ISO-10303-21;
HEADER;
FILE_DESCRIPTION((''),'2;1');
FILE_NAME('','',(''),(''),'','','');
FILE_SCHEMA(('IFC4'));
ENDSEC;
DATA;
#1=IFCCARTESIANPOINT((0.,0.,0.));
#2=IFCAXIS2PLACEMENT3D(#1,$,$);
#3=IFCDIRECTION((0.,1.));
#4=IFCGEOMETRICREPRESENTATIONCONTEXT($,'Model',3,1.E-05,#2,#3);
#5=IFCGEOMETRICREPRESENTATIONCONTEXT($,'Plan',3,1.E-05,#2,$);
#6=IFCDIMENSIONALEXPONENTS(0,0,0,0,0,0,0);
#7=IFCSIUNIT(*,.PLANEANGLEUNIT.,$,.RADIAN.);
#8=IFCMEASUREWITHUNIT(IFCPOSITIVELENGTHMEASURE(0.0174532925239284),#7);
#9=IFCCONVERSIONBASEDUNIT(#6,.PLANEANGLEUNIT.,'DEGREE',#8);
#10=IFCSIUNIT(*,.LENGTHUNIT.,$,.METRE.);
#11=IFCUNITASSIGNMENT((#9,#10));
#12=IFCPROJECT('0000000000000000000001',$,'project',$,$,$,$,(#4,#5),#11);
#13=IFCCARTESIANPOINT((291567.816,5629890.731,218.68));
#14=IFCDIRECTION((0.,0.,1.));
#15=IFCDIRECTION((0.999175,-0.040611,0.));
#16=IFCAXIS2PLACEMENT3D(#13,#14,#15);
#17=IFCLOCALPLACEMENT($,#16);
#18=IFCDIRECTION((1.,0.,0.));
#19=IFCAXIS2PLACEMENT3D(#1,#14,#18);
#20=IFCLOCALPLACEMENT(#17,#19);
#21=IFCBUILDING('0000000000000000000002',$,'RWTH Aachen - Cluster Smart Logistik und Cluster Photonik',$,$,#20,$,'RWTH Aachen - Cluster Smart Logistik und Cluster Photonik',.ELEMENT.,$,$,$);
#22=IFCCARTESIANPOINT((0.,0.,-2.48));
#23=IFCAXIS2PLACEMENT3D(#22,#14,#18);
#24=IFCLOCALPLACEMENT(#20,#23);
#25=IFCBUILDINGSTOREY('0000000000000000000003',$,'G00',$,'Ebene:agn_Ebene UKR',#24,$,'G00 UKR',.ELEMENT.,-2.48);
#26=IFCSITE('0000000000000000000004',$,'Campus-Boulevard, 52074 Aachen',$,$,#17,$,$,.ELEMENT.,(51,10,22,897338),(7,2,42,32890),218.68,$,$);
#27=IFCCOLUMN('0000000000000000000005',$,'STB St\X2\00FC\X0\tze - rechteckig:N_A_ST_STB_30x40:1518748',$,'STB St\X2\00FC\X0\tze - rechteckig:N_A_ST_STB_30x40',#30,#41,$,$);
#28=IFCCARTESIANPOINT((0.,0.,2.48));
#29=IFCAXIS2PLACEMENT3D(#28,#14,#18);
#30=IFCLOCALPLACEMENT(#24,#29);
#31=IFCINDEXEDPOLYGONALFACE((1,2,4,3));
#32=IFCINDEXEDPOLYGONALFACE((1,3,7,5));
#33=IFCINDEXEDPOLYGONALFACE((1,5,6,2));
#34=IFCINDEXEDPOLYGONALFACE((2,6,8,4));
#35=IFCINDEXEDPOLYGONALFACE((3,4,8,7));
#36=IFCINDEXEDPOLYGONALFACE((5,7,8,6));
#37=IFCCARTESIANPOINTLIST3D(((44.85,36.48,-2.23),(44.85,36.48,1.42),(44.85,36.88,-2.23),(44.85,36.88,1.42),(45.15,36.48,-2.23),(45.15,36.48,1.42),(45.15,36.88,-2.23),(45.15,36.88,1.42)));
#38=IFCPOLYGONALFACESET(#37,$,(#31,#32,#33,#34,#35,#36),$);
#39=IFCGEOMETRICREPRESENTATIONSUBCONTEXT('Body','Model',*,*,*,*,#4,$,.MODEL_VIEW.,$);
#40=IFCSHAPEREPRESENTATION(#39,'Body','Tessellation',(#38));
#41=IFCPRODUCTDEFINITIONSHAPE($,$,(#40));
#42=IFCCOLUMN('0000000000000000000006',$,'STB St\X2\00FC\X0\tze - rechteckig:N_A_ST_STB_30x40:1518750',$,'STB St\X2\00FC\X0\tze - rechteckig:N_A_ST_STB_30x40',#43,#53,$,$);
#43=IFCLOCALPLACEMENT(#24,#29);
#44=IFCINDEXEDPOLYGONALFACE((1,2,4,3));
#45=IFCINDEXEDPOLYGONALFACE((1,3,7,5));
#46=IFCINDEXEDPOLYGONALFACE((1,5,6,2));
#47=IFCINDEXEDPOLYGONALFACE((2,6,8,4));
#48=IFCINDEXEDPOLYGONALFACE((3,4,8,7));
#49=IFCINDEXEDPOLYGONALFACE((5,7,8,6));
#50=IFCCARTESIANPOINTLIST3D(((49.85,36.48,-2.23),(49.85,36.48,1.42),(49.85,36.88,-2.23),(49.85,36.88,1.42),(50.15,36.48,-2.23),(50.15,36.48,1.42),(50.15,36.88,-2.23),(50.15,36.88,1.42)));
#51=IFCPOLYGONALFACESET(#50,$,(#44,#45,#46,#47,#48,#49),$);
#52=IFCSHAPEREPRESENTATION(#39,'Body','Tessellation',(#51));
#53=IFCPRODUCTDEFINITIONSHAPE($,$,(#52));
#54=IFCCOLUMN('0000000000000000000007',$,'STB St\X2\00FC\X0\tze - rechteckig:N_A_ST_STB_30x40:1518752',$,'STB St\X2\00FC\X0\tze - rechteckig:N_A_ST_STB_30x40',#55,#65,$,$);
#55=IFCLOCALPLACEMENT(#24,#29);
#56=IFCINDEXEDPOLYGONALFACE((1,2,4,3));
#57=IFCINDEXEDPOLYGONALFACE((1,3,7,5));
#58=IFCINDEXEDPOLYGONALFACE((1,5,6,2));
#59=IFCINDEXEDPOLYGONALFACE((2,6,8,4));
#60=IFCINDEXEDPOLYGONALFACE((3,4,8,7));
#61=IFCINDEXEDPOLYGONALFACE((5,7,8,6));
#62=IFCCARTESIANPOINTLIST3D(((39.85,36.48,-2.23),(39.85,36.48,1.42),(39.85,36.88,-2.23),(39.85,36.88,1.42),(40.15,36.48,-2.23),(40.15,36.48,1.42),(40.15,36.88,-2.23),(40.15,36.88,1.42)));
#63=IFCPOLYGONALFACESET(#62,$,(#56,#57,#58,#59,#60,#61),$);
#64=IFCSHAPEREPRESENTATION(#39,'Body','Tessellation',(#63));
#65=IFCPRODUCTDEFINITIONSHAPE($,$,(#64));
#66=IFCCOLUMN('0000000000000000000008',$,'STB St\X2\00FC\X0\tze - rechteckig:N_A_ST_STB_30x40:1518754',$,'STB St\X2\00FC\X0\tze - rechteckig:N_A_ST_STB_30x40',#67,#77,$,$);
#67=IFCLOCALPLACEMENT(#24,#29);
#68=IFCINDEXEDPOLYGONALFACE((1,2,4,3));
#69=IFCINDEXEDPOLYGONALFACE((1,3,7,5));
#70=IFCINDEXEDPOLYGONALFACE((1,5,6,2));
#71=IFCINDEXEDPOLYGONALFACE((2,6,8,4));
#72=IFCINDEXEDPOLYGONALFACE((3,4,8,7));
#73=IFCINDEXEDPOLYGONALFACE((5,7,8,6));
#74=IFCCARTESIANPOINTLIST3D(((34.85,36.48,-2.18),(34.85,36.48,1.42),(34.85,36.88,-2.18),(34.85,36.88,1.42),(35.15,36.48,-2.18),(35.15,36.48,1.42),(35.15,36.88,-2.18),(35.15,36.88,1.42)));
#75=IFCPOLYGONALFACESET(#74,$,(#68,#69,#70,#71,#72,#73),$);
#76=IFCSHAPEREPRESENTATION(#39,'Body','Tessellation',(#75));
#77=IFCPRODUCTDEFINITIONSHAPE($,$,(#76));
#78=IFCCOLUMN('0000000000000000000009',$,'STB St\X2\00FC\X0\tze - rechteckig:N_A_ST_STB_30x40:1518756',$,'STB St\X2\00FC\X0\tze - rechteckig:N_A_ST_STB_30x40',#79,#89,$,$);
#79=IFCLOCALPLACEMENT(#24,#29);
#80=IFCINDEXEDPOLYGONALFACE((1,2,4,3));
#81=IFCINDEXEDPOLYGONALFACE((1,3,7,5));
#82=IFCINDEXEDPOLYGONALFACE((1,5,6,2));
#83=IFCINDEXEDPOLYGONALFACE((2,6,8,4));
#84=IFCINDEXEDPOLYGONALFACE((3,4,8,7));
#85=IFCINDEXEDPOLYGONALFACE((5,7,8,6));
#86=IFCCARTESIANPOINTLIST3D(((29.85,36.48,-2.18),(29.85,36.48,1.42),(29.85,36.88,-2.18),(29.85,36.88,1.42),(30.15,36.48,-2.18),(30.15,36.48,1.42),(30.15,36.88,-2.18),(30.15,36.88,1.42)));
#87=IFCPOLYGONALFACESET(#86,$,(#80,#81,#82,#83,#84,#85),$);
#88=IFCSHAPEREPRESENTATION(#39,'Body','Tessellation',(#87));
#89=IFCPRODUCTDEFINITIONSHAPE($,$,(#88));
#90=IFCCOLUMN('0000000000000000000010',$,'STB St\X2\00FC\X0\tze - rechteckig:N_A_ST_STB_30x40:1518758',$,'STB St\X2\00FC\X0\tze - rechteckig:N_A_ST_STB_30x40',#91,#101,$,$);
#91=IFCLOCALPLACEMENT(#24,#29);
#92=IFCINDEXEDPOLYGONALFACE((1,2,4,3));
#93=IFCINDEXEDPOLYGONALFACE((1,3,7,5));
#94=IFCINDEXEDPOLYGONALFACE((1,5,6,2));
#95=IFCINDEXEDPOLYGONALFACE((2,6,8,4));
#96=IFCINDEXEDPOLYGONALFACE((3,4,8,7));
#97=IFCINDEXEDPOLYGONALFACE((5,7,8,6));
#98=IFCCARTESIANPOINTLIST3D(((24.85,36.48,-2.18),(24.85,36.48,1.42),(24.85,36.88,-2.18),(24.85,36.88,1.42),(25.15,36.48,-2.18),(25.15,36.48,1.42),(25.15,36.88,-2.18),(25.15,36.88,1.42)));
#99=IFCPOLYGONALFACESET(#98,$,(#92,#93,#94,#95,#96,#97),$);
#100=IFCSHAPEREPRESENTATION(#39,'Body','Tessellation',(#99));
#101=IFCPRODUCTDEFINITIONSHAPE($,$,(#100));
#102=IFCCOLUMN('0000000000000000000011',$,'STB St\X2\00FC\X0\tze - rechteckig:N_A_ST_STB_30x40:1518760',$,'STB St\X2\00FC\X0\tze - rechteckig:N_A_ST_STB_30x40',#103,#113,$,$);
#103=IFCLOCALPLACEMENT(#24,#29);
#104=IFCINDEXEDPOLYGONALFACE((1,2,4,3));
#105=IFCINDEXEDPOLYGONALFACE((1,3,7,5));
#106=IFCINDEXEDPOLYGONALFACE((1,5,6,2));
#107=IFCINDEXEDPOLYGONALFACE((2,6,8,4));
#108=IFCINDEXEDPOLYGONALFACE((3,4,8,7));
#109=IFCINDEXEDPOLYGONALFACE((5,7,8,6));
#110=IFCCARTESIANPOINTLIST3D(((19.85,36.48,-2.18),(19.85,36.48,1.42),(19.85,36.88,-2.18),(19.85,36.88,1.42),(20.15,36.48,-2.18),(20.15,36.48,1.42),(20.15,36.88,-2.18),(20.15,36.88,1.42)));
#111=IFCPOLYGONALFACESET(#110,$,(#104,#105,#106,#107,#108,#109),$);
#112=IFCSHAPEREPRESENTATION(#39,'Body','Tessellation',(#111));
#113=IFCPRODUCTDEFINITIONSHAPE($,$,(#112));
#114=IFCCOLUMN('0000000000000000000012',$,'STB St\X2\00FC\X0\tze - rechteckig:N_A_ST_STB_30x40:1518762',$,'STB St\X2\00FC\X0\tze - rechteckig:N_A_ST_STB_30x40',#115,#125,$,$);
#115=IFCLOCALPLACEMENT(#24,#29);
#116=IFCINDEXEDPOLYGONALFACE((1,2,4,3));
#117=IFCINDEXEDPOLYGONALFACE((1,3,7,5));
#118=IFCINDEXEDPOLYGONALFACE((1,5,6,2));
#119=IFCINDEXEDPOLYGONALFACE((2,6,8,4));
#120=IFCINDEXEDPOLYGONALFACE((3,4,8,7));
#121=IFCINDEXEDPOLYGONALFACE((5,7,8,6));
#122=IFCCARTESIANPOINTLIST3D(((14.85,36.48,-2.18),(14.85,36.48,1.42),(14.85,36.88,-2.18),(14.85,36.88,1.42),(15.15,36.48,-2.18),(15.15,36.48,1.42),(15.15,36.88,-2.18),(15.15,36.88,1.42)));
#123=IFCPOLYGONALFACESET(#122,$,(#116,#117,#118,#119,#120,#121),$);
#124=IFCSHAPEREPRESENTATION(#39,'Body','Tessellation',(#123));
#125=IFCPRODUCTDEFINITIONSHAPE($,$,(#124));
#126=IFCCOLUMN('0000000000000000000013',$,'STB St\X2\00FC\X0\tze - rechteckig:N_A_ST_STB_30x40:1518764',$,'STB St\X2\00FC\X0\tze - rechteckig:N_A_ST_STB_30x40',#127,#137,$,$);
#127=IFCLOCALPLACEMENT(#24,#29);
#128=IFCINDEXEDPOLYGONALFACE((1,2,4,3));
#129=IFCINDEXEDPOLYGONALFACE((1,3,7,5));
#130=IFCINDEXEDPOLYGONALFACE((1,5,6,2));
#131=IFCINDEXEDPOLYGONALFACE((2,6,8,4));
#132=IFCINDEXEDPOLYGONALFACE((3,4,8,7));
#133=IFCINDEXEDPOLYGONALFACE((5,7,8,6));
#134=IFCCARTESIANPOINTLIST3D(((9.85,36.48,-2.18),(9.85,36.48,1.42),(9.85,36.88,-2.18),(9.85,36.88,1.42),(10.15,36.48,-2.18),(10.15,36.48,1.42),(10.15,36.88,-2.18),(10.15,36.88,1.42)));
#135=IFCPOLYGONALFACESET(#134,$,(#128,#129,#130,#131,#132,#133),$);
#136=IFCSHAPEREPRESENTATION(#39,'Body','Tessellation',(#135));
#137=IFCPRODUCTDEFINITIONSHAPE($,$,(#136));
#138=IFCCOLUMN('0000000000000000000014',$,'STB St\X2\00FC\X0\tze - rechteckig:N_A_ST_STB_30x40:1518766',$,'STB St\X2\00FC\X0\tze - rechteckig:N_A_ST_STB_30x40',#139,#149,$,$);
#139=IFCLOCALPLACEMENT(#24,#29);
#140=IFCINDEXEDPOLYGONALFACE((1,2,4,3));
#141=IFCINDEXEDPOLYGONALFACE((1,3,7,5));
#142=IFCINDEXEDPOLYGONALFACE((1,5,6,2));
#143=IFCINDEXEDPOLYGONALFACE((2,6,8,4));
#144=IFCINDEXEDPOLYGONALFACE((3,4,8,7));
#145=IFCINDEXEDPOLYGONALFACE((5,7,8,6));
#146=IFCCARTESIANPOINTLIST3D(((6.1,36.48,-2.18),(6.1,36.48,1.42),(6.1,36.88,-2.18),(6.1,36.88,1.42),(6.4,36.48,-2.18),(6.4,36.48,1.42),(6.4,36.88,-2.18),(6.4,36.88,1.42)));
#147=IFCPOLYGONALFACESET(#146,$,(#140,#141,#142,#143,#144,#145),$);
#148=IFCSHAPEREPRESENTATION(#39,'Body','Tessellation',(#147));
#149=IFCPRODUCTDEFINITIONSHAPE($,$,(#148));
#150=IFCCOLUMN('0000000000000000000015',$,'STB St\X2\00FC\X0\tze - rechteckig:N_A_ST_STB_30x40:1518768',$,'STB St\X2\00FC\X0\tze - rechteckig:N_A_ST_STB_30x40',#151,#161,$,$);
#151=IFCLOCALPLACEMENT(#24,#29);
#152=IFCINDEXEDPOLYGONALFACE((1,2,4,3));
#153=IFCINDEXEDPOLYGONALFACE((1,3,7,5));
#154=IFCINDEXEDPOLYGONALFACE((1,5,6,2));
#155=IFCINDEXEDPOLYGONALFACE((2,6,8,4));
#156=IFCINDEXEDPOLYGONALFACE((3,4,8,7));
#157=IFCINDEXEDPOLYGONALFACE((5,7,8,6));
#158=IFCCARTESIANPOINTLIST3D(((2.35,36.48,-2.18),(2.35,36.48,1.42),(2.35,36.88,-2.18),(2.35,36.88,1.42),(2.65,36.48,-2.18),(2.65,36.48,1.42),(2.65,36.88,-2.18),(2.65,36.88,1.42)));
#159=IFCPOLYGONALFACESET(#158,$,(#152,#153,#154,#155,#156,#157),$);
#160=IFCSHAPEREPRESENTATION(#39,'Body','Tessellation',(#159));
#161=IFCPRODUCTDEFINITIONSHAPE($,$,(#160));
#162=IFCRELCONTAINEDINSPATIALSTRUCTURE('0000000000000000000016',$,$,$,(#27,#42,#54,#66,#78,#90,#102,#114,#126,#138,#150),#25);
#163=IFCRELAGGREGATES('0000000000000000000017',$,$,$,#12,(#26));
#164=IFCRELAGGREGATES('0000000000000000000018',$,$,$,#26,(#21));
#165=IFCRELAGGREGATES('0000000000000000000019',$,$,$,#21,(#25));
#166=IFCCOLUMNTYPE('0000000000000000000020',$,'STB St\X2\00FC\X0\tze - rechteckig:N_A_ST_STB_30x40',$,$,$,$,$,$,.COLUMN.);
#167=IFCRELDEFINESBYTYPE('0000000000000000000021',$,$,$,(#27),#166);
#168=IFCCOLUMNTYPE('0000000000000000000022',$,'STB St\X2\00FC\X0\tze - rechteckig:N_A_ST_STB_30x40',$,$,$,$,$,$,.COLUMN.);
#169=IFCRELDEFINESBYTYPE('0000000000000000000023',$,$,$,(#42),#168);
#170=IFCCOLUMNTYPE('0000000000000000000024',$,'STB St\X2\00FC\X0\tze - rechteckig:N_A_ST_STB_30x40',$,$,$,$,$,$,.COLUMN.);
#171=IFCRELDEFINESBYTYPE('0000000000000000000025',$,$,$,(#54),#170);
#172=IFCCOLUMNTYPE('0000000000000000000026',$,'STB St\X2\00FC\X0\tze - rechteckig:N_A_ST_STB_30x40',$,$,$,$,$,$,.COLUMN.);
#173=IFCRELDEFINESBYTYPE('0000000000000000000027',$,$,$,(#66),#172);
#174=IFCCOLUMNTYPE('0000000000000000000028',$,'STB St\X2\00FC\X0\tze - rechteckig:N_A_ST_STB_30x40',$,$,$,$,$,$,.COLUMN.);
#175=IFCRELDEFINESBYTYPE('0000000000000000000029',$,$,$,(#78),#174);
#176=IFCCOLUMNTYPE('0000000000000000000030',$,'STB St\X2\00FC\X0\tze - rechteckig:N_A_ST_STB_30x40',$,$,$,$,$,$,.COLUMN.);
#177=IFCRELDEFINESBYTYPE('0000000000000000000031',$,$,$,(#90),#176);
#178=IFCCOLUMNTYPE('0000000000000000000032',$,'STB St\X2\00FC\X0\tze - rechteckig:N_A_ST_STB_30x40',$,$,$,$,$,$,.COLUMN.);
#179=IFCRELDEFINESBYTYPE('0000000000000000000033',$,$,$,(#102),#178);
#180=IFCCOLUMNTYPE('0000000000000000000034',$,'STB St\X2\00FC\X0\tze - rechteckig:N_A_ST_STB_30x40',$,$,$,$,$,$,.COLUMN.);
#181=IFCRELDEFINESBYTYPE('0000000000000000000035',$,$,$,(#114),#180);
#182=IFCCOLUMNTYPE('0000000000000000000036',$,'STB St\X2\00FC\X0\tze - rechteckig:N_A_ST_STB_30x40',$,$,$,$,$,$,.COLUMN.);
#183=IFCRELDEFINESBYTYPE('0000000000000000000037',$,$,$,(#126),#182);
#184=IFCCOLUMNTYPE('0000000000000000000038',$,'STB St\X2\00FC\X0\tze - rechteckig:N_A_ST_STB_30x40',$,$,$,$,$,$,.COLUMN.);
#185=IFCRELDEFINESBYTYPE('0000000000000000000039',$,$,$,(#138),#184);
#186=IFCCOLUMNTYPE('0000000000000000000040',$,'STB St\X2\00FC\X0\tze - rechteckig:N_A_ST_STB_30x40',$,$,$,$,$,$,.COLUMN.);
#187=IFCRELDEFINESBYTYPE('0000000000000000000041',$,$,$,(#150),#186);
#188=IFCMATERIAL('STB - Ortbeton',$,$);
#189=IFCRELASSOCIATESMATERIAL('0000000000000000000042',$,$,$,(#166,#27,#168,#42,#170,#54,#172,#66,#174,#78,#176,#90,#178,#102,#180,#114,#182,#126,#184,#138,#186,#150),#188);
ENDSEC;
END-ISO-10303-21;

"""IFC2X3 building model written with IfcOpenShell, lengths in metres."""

from ifc_helpers import new_model, entity, si_unit, converted_unit, direction, frame, frame_2d, origin, origin_with_axes, origin_2d_with_axis, place, context, subcontext, project, spatial, rectangle, extrude, source, transform, mapped, material, type_object, element, save


model = new_model("IFC2X3")

# Units and contexts
model_context = context("Model", 3, precision=1e-05, world=origin(), true_north=direction((0.0, 1.0)))
plan_context = context("Plan", 3, precision=1e-05, world=origin())
body_context = subcontext(model_context, "Body", "Model", "MODEL_VIEW")
ifc_project = project(units=[converted_unit("PLANEANGLEUNIT", "DEGREE", entity("IfcPositiveLengthMeasure", 0.0174532925239284), si_unit("PLANEANGLEUNIT", "RADIAN"), dimensions=[0, 0, 0, 0, 0, 0, 0]), si_unit("LENGTHUNIT", "METRE")], contexts=[model_context, plan_context])

# Site, building, storey
site_placement = place(None, frame((291567.816, 5629890.731, 218.68), z_axis=(0.0, 0.0, 1.0), x_axis=(0.999175, -0.040611, 0.0)))
site = spatial("IfcSite", under=ifc_project, at=site_placement, Name="Campus-Boulevard, 52074 Aachen", CompositionType="ELEMENT", RefLatitude=(51, 10, 22, 897338), RefLongitude=(7, 2, 42, 32890), RefElevation=218.68)
building_placement = place(site_placement, origin_with_axes())
building = spatial("IfcBuilding", under=site, at=building_placement, Name="RWTH Aachen - Cluster Smart Logistik und Cluster Photonik", LongName="RWTH Aachen - Cluster Smart Logistik und Cluster Photonik", CompositionType="ELEMENT")
storey_placement = place(building_placement, frame((0.0, 0.0, -2.48), z_axis=(0.0, 0.0, 1.0), x_axis=(1.0, 0.0, 0.0)))
storey = spatial("IfcBuildingStorey", under=building, at=storey_placement, Name="G00", ObjectType="Ebene:agn_Ebene UKR", LongName="G00 UKR", CompositionType="ELEMENT", Elevation=-2.48)

# Shared definitions
ifc_material = material(Name="STB - Ortbeton")

# Columns
column_type_1 = type_object("IfcColumnType", Name="STB Stütze - rechteckig:N_A_ST_STB_30x40", PredefinedType="COLUMN", material=ifc_material)
shared_shape_1 = source(origin(), body_context, "Body", "SweptSolid", [
    extrude(rectangle(XDim=0.4, YDim=0.3, at=frame_2d((0.0, 0.0), x_axis=(1.0, 0.0))), frame((45.0, 36.68, -2.23), z_axis=(0.0, 0.0, 1.0), x_axis=(0.0, -1.0, 0.0)), (0.0, 0.0, 1.0), 3.65),
])
column_1_placement = place(storey_placement, frame((0.0, 0.0, 2.48), z_axis=(0.0, 0.0, 1.0), x_axis=(1.0, 0.0, 0.0)))
element("IfcColumn", 1, at=column_1_placement, inside=storey, type_object=column_type_1, material=ifc_material, Name="STB Stütze - rechteckig:N_A_ST_STB_30x40:1518748", ObjectType="STB Stütze - rechteckig:N_A_ST_STB_30x40", context=body_context, shape_type="MappedRepresentation", body=[
    mapped(shared_shape_1, transform((0.0, 0.0, 0.0), scale=1.0)),
])
column_type_2 = type_object("IfcColumnType", Name="STB Stütze - rechteckig:N_A_ST_STB_30x40", PredefinedType="COLUMN", material=ifc_material)
shared_shape_2 = source(origin(), body_context, "Body", "SweptSolid", [
    extrude(rectangle(XDim=0.4, YDim=0.3, at=frame_2d((0.0, 0.0), x_axis=(1.0, 0.0))), frame((50.0, 36.68, -2.23), z_axis=(0.0, 0.0, 1.0), x_axis=(0.0, -1.0, 0.0)), (0.0, 0.0, 1.0), 3.65),
])
column_2_placement = place(storey_placement, frame((0.0, 0.0, 2.48), z_axis=(0.0, 0.0, 1.0), x_axis=(1.0, 0.0, 0.0)))
element("IfcColumn", 2, at=column_2_placement, inside=storey, type_object=column_type_2, material=ifc_material, Name="STB Stütze - rechteckig:N_A_ST_STB_30x40:1518750", ObjectType="STB Stütze - rechteckig:N_A_ST_STB_30x40", context=body_context, shape_type="MappedRepresentation", body=[
    mapped(shared_shape_2, transform((0.0, 0.0, 0.0), scale=1.0)),
])
column_type_3 = type_object("IfcColumnType", Name="STB Stütze - rechteckig:N_A_ST_STB_30x40", PredefinedType="COLUMN", material=ifc_material)
shared_shape_3 = source(origin(), body_context, "Body", "SweptSolid", [
    extrude(rectangle(XDim=0.4, YDim=0.3, at=frame_2d((0.0, 0.0), x_axis=(1.0, 0.0))), frame((40.0, 36.68, -2.23), z_axis=(0.0, 0.0, 1.0), x_axis=(0.0, -1.0, 0.0)), (0.0, 0.0, 1.0), 3.65),
])
column_3_placement = place(storey_placement, frame((0.0, 0.0, 2.48), z_axis=(0.0, 0.0, 1.0), x_axis=(1.0, 0.0, 0.0)))
element("IfcColumn", 3, at=column_3_placement, inside=storey, type_object=column_type_3, material=ifc_material, Name="STB Stütze - rechteckig:N_A_ST_STB_30x40:1518752", ObjectType="STB Stütze - rechteckig:N_A_ST_STB_30x40", context=body_context, shape_type="MappedRepresentation", body=[
    mapped(shared_shape_3, transform((0.0, 0.0, 0.0), scale=1.0)),
])
column_type_4 = type_object("IfcColumnType", Name="STB Stütze - rechteckig:N_A_ST_STB_30x40", PredefinedType="COLUMN", material=ifc_material)
shared_shape_4 = source(origin(), body_context, "Body", "SweptSolid", [
    extrude(rectangle(XDim=0.4, YDim=0.3, at=origin_2d_with_axis()), frame((35.0, 36.68, -2.18), z_axis=(0.0, 0.0, 1.0), x_axis=(0.0, -1.0, 0.0)), (0.0, 0.0, 1.0), 3.6),
])
column_4_placement = place(storey_placement, frame((0.0, 0.0, 2.48), z_axis=(0.0, 0.0, 1.0), x_axis=(1.0, 0.0, 0.0)))
element("IfcColumn", 4, at=column_4_placement, inside=storey, type_object=column_type_4, material=ifc_material, Name="STB Stütze - rechteckig:N_A_ST_STB_30x40:1518754", ObjectType="STB Stütze - rechteckig:N_A_ST_STB_30x40", context=body_context, shape_type="MappedRepresentation", body=[
    mapped(shared_shape_4, transform((0.0, 0.0, 0.0), scale=1.0)),
])
column_type_5 = type_object("IfcColumnType", Name="STB Stütze - rechteckig:N_A_ST_STB_30x40", PredefinedType="COLUMN", material=ifc_material)
shared_shape_5 = source(origin(), body_context, "Body", "SweptSolid", [
    extrude(rectangle(XDim=0.4, YDim=0.3, at=origin_2d_with_axis()), frame((30.0, 36.68, -2.18), z_axis=(0.0, 0.0, 1.0), x_axis=(0.0, -1.0, 0.0)), (0.0, 0.0, 1.0), 3.6),
])
column_5_placement = place(storey_placement, frame((0.0, 0.0, 2.48), z_axis=(0.0, 0.0, 1.0), x_axis=(1.0, 0.0, 0.0)))
element("IfcColumn", 5, at=column_5_placement, inside=storey, type_object=column_type_5, material=ifc_material, Name="STB Stütze - rechteckig:N_A_ST_STB_30x40:1518756", ObjectType="STB Stütze - rechteckig:N_A_ST_STB_30x40", context=body_context, shape_type="MappedRepresentation", body=[
    mapped(shared_shape_5, transform((0.0, 0.0, 0.0), scale=1.0)),
])
column_type_6 = type_object("IfcColumnType", Name="STB Stütze - rechteckig:N_A_ST_STB_30x40", PredefinedType="COLUMN", material=ifc_material)
shared_shape_6 = source(origin(), body_context, "Body", "SweptSolid", [
    extrude(rectangle(XDim=0.4, YDim=0.3, at=frame_2d((0.0, 0.0), x_axis=(1.0, 0.0))), frame((25.0, 36.68, -2.18), z_axis=(0.0, 0.0, 1.0), x_axis=(0.0, -1.0, 0.0)), (0.0, 0.0, 1.0), 3.6),
])
column_6_placement = place(storey_placement, frame((0.0, 0.0, 2.48), z_axis=(0.0, 0.0, 1.0), x_axis=(1.0, 0.0, 0.0)))
element("IfcColumn", 6, at=column_6_placement, inside=storey, type_object=column_type_6, material=ifc_material, Name="STB Stütze - rechteckig:N_A_ST_STB_30x40:1518758", ObjectType="STB Stütze - rechteckig:N_A_ST_STB_30x40", context=body_context, shape_type="MappedRepresentation", body=[
    mapped(shared_shape_6, transform((0.0, 0.0, 0.0), scale=1.0)),
])
column_type_7 = type_object("IfcColumnType", Name="STB Stütze - rechteckig:N_A_ST_STB_30x40", PredefinedType="COLUMN", material=ifc_material)
shared_shape_7 = source(origin(), body_context, "Body", "SweptSolid", [
    extrude(rectangle(XDim=0.4, YDim=0.3, at=frame_2d((0.0, 0.0), x_axis=(1.0, 0.0))), frame((20.0, 36.68, -2.18), z_axis=(0.0, 0.0, 1.0), x_axis=(0.0, -1.0, 0.0)), (0.0, 0.0, 1.0), 3.6),
])
column_7_placement = place(storey_placement, frame((0.0, 0.0, 2.48), z_axis=(0.0, 0.0, 1.0), x_axis=(1.0, 0.0, 0.0)))
element("IfcColumn", 7, at=column_7_placement, inside=storey, type_object=column_type_7, material=ifc_material, Name="STB Stütze - rechteckig:N_A_ST_STB_30x40:1518760", ObjectType="STB Stütze - rechteckig:N_A_ST_STB_30x40", context=body_context, shape_type="MappedRepresentation", body=[
    mapped(shared_shape_7, transform((0.0, 0.0, 0.0), scale=1.0)),
])
column_type_8 = type_object("IfcColumnType", Name="STB Stütze - rechteckig:N_A_ST_STB_30x40", PredefinedType="COLUMN", material=ifc_material)
shared_shape_8 = source(origin(), body_context, "Body", "SweptSolid", [
    extrude(rectangle(XDim=0.4, YDim=0.3, at=frame_2d((0.0, 0.0), x_axis=(1.0, 0.0))), frame((15.0, 36.68, -2.18), z_axis=(0.0, 0.0, 1.0), x_axis=(0.0, -1.0, 0.0)), (0.0, 0.0, 1.0), 3.6),
])
column_8_placement = place(storey_placement, frame((0.0, 0.0, 2.48), z_axis=(0.0, 0.0, 1.0), x_axis=(1.0, 0.0, 0.0)))
element("IfcColumn", 8, at=column_8_placement, inside=storey, type_object=column_type_8, material=ifc_material, Name="STB Stütze - rechteckig:N_A_ST_STB_30x40:1518762", ObjectType="STB Stütze - rechteckig:N_A_ST_STB_30x40", context=body_context, shape_type="MappedRepresentation", body=[
    mapped(shared_shape_8, transform((0.0, 0.0, 0.0), scale=1.0)),
])
column_type_9 = type_object("IfcColumnType", Name="STB Stütze - rechteckig:N_A_ST_STB_30x40", PredefinedType="COLUMN", material=ifc_material)
shared_shape_9 = source(origin(), body_context, "Body", "SweptSolid", [
    extrude(rectangle(XDim=0.4, YDim=0.3, at=origin_2d_with_axis()), frame((10.0, 36.68, -2.18), z_axis=(0.0, 0.0, 1.0), x_axis=(0.0, -1.0, 0.0)), (0.0, 0.0, 1.0), 3.6),
])
column_9_placement = place(storey_placement, frame((0.0, 0.0, 2.48), z_axis=(0.0, 0.0, 1.0), x_axis=(1.0, 0.0, 0.0)))
element("IfcColumn", 9, at=column_9_placement, inside=storey, type_object=column_type_9, material=ifc_material, Name="STB Stütze - rechteckig:N_A_ST_STB_30x40:1518764", ObjectType="STB Stütze - rechteckig:N_A_ST_STB_30x40", context=body_context, shape_type="MappedRepresentation", body=[
    mapped(shared_shape_9, transform((0.0, 0.0, 0.0), scale=1.0)),
])
column_type_10 = type_object("IfcColumnType", Name="STB Stütze - rechteckig:N_A_ST_STB_30x40", PredefinedType="COLUMN", material=ifc_material)
shared_shape_10 = source(origin(), body_context, "Body", "SweptSolid", [
    extrude(rectangle(XDim=0.4, YDim=0.3, at=frame_2d((0.0, 0.0), x_axis=(1.0, 0.0))), frame((6.25, 36.68, -2.18), z_axis=(0.0, 0.0, 1.0), x_axis=(0.0, -1.0, 0.0)), (0.0, 0.0, 1.0), 3.6),
])
column_10_placement = place(storey_placement, frame((0.0, 0.0, 2.48), z_axis=(0.0, 0.0, 1.0), x_axis=(1.0, 0.0, 0.0)))
element("IfcColumn", 10, at=column_10_placement, inside=storey, type_object=column_type_10, material=ifc_material, Name="STB Stütze - rechteckig:N_A_ST_STB_30x40:1518766", ObjectType="STB Stütze - rechteckig:N_A_ST_STB_30x40", context=body_context, shape_type="MappedRepresentation", body=[
    mapped(shared_shape_10, transform((0.0, 0.0, 0.0), scale=1.0)),
])
column_type_11 = type_object("IfcColumnType", Name="STB Stütze - rechteckig:N_A_ST_STB_30x40", PredefinedType="COLUMN", material=ifc_material)
shared_shape_11 = source(origin(), body_context, "Body", "SweptSolid", [
    extrude(rectangle(XDim=0.4, YDim=0.3, at=origin_2d_with_axis()), frame((2.5, 36.68, -2.18), z_axis=(0.0, 0.0, 1.0), x_axis=(0.0, -1.0, 0.0)), (0.0, 0.0, 1.0), 3.6),
])
column_11_placement = place(storey_placement, frame((0.0, 0.0, 2.48), z_axis=(0.0, 0.0, 1.0), x_axis=(1.0, 0.0, 0.0)))
element("IfcColumn", 11, at=column_11_placement, inside=storey, type_object=column_type_11, material=ifc_material, Name="STB Stütze - rechteckig:N_A_ST_STB_30x40:1518768", ObjectType="STB Stütze - rechteckig:N_A_ST_STB_30x40", context=body_context, shape_type="MappedRepresentation", body=[
    mapped(shared_shape_11, transform((0.0, 0.0, 0.0), scale=1.0)),
])

save(model, "model.ifc")
